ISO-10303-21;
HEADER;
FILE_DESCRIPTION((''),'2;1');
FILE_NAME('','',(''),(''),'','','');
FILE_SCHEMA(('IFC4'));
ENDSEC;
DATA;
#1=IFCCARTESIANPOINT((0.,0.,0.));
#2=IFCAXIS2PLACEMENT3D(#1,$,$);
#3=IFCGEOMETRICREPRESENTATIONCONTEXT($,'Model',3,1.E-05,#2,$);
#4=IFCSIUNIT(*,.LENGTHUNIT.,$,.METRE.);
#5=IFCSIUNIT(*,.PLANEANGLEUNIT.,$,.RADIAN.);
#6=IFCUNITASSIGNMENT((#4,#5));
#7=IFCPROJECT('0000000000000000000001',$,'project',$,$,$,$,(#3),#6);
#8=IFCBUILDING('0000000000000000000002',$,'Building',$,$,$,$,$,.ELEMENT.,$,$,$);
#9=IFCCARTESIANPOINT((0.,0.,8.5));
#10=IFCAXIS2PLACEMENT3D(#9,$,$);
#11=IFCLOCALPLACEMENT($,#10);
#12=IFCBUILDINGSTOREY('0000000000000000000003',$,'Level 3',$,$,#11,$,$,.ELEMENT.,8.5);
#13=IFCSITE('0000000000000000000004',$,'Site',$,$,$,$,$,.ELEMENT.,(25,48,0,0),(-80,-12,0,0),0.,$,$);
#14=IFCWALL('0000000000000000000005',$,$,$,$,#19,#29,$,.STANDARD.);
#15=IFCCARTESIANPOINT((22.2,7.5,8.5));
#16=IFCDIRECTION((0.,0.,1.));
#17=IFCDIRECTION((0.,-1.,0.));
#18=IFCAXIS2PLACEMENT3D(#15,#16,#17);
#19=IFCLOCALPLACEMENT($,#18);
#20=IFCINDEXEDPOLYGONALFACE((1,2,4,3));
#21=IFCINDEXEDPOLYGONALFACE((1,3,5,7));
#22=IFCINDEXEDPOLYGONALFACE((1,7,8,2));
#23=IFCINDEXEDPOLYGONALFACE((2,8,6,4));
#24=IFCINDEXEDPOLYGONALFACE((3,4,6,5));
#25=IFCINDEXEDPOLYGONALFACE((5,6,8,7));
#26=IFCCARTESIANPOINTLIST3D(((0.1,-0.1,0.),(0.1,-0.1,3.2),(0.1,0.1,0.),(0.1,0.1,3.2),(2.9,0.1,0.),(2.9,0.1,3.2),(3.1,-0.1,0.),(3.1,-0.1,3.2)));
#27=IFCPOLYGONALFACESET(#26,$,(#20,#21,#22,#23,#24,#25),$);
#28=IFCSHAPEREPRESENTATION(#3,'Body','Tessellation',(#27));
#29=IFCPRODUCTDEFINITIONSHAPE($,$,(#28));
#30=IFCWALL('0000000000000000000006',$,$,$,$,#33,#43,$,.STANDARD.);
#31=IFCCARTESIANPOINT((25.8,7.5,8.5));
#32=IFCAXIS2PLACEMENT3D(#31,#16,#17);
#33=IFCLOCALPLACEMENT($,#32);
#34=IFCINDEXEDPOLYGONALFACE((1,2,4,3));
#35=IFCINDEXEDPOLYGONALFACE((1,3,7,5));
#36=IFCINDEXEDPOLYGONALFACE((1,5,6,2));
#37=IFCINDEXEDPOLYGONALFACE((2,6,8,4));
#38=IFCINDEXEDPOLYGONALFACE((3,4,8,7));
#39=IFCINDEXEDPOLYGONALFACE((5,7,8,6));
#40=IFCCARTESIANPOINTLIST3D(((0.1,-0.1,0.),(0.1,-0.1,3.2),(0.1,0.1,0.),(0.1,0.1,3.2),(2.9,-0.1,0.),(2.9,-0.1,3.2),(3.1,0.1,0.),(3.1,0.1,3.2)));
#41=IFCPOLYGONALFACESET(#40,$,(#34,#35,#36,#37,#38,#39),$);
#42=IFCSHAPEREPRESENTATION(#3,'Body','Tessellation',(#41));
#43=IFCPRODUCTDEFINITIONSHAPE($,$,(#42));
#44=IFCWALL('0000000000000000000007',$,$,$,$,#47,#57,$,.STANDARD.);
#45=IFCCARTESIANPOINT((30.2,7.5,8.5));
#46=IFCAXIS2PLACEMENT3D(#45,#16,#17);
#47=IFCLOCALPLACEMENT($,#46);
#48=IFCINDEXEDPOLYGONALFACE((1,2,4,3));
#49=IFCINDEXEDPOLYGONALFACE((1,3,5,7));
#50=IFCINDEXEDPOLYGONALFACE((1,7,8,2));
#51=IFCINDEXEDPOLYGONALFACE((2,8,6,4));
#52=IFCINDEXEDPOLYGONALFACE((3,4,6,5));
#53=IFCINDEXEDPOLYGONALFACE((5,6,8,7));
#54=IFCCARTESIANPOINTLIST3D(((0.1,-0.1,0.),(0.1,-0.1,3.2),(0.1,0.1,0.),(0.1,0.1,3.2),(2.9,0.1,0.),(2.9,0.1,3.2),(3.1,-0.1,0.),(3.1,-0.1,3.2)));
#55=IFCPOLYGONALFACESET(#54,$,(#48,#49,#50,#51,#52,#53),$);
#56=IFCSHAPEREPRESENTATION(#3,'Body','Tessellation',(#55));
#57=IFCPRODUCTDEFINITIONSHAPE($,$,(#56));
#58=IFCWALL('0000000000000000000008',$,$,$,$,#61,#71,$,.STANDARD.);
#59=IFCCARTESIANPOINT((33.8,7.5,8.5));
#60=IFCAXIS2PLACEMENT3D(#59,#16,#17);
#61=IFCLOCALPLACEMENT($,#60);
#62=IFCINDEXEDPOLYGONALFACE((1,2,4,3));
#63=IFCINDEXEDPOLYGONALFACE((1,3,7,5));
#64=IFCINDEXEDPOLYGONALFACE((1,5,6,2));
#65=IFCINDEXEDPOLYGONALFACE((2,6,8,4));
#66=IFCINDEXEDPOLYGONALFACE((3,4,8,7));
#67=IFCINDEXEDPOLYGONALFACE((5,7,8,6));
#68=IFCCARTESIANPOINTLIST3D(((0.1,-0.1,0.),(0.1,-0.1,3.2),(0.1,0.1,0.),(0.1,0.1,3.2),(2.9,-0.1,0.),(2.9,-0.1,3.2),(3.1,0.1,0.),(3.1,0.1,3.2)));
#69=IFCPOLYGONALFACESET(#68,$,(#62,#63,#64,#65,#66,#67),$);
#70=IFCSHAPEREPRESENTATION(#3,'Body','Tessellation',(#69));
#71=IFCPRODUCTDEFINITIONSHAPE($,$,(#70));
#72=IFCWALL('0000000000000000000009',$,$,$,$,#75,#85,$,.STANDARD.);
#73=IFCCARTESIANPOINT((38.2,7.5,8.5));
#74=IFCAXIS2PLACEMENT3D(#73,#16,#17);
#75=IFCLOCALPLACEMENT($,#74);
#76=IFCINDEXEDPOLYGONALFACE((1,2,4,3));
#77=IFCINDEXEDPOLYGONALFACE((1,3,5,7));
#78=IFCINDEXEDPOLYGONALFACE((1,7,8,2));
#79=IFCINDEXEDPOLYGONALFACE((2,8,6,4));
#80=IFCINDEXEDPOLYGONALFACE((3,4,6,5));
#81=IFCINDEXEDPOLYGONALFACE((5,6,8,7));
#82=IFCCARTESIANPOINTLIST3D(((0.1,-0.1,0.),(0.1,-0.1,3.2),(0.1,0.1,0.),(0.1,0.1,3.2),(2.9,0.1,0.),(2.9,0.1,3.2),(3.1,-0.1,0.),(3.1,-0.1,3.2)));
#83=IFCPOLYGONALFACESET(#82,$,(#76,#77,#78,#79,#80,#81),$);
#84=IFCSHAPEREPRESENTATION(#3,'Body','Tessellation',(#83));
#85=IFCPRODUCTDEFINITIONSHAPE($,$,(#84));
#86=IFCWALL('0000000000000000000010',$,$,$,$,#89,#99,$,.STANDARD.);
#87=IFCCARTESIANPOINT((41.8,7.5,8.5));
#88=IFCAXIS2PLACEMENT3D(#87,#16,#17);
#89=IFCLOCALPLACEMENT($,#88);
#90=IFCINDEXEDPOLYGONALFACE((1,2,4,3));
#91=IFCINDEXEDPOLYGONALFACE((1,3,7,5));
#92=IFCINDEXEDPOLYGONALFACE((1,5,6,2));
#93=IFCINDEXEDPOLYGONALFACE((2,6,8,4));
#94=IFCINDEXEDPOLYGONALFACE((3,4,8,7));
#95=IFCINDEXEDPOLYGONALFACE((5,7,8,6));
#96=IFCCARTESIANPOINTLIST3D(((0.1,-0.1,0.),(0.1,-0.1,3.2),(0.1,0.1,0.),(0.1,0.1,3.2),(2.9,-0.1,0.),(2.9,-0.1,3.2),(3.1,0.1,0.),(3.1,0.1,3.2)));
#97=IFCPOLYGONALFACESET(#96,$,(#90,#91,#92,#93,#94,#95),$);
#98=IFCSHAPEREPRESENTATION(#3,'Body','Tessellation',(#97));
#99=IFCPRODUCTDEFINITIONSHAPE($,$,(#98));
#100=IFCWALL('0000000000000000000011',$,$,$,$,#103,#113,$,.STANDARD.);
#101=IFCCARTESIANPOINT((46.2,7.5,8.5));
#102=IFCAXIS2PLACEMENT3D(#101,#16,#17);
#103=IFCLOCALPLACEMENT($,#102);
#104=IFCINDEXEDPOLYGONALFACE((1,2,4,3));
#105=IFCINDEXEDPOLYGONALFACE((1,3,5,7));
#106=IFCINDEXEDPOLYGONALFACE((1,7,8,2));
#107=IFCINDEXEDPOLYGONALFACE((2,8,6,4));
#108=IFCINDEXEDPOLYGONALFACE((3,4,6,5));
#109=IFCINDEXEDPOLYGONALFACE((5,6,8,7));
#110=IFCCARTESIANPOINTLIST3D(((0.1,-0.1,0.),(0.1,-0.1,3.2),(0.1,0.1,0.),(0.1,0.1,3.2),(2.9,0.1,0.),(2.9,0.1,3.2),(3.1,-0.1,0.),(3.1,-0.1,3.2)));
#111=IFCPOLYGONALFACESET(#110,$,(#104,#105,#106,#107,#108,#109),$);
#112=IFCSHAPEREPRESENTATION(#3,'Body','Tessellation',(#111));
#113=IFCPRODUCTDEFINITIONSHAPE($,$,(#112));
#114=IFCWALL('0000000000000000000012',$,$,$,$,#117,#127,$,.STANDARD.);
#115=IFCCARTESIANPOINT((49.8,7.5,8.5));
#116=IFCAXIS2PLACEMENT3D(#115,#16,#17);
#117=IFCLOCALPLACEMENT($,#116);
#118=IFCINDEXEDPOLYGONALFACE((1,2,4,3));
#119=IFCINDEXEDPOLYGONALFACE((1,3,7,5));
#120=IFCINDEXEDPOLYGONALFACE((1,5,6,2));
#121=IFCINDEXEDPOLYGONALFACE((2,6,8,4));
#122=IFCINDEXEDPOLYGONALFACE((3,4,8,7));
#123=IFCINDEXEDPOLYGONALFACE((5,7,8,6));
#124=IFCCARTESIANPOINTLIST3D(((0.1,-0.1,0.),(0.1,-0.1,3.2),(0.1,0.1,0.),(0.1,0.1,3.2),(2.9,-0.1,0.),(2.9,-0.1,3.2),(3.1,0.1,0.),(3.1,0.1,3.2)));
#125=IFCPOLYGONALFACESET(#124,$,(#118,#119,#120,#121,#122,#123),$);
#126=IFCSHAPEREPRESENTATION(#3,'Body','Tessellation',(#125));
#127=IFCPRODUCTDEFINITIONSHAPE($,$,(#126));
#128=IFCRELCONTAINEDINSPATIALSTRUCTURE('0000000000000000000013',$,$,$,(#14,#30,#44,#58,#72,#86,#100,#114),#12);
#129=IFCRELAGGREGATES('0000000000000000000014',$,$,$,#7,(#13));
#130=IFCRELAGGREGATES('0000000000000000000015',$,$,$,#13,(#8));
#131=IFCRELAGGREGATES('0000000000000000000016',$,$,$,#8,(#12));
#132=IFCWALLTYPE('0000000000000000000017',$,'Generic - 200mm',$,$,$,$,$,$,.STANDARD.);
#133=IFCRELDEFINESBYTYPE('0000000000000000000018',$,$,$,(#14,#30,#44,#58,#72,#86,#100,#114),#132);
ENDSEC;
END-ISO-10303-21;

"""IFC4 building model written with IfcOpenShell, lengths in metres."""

from ifc_helpers import new_model, si_unit, frame, origin, place, context, project, spatial, polyline, outline, extrude, type_object, element, save


model = new_model("IFC4")

# Units and contexts
model_context = context("Model", 3, precision=1e-05, world=origin())
ifc_project = project(units=[si_unit("LENGTHUNIT", "METRE"), si_unit("PLANEANGLEUNIT", "RADIAN")], contexts=[model_context])

# Site, building, storey
site = spatial("IfcSite", under=ifc_project, Name="Site", CompositionType="ELEMENT", RefLatitude=(25, 48, 0, 0), RefLongitude=(-80, -12, 0, 0), RefElevation=0.0)
building = spatial("IfcBuilding", under=site, Name="Building", CompositionType="ELEMENT")
storey_placement = place(None, frame((0.0, 0.0, 8.5)))
storey = spatial("IfcBuildingStorey", under=building, at=storey_placement, Name="Level 3", CompositionType="ELEMENT", Elevation=8.5)

# Shared definitions
wall_type = type_object("IfcWallType", Name="Generic - 200mm", PredefinedType="STANDARD")

# Walls
wall_1_placement = place(None, frame((22.2, 7.5, 8.5), z_axis=(0.0, 0.0, 1.0), x_axis=(0.0, -1.0, 0.0)))
element("IfcWall", 1, at=wall_1_placement, inside=storey, type_object=wall_type, PredefinedType="STANDARD", context=model_context, shape_type="SweptSolid", body=[
    extrude(outline(polyline([(0.1, -0.1), (3.1, -0.1), (2.9, 0.1), (0.1, 0.1), (0.1, -0.1)])), origin(), (0.0, 0.0, 1.0), 3.2),
])
wall_2_placement = place(None, frame((25.8, 7.5, 8.5), z_axis=(0.0, 0.0, 1.0), x_axis=(0.0, -1.0, 0.0)))
element("IfcWall", 2, at=wall_2_placement, inside=storey, type_object=wall_type, PredefinedType="STANDARD", context=model_context, shape_type="SweptSolid", body=[
    extrude(outline(polyline([(0.1, -0.1), (2.9, -0.1), (3.1, 0.1), (0.1, 0.1), (0.1, -0.1)])), origin(), (0.0, 0.0, 1.0), 3.2),
])
wall_3_placement = place(None, frame((30.2, 7.5, 8.5), z_axis=(0.0, 0.0, 1.0), x_axis=(0.0, -1.0, 0.0)))
element("IfcWall", 3, at=wall_3_placement, inside=storey, type_object=wall_type, PredefinedType="STANDARD", context=model_context, shape_type="SweptSolid", body=[
    extrude(outline(polyline([(0.1, -0.1), (3.1, -0.1), (2.9, 0.1), (0.1, 0.1), (0.1, -0.1)])), origin(), (0.0, 0.0, 1.0), 3.2),
])
wall_4_placement = place(None, frame((33.8, 7.5, 8.5), z_axis=(0.0, 0.0, 1.0), x_axis=(0.0, -1.0, 0.0)))
element("IfcWall", 4, at=wall_4_placement, inside=storey, type_object=wall_type, PredefinedType="STANDARD", context=model_context, shape_type="SweptSolid", body=[
    extrude(outline(polyline([(0.1, -0.1), (2.9, -0.1), (3.1, 0.1), (0.1, 0.1), (0.1, -0.1)])), origin(), (0.0, 0.0, 1.0), 3.2),
])
wall_5_placement = place(None, frame((38.2, 7.5, 8.5), z_axis=(0.0, 0.0, 1.0), x_axis=(0.0, -1.0, 0.0)))
element("IfcWall", 5, at=wall_5_placement, inside=storey, type_object=wall_type, PredefinedType="STANDARD", context=model_context, shape_type="SweptSolid", body=[
    extrude(outline(polyline([(0.1, -0.1), (3.1, -0.1), (2.9, 0.1), (0.1, 0.1), (0.1, -0.1)])), origin(), (0.0, 0.0, 1.0), 3.2),
])
wall_6_placement = place(None, frame((41.8, 7.5, 8.5), z_axis=(0.0, 0.0, 1.0), x_axis=(0.0, -1.0, 0.0)))
element("IfcWall", 6, at=wall_6_placement, inside=storey, type_object=wall_type, PredefinedType="STANDARD", context=model_context, shape_type="SweptSolid", body=[
    extrude(outline(polyline([(0.1, -0.1), (2.9, -0.1), (3.1, 0.1), (0.1, 0.1), (0.1, -0.1)])), origin(), (0.0, 0.0, 1.0), 3.2),
])
wall_7_placement = place(None, frame((46.2, 7.5, 8.5), z_axis=(0.0, 0.0, 1.0), x_axis=(0.0, -1.0, 0.0)))
element("IfcWall", 7, at=wall_7_placement, inside=storey, type_object=wall_type, PredefinedType="STANDARD", context=model_context, shape_type="SweptSolid", body=[
    extrude(outline(polyline([(0.1, -0.1), (3.1, -0.1), (2.9, 0.1), (0.1, 0.1), (0.1, -0.1)])), origin(), (0.0, 0.0, 1.0), 3.2),
])
wall_8_placement = place(None, frame((49.8, 7.5, 8.5), z_axis=(0.0, 0.0, 1.0), x_axis=(0.0, -1.0, 0.0)))
element("IfcWall", 8, at=wall_8_placement, inside=storey, type_object=wall_type, PredefinedType="STANDARD", context=model_context, shape_type="SweptSolid", body=[
    extrude(outline(polyline([(0.1, -0.1), (2.9, -0.1), (3.1, 0.1), (0.1, 0.1), (0.1, -0.1)])), origin(), (0.0, 0.0, 1.0), 3.2),
])

save(model, "model.ifc")
